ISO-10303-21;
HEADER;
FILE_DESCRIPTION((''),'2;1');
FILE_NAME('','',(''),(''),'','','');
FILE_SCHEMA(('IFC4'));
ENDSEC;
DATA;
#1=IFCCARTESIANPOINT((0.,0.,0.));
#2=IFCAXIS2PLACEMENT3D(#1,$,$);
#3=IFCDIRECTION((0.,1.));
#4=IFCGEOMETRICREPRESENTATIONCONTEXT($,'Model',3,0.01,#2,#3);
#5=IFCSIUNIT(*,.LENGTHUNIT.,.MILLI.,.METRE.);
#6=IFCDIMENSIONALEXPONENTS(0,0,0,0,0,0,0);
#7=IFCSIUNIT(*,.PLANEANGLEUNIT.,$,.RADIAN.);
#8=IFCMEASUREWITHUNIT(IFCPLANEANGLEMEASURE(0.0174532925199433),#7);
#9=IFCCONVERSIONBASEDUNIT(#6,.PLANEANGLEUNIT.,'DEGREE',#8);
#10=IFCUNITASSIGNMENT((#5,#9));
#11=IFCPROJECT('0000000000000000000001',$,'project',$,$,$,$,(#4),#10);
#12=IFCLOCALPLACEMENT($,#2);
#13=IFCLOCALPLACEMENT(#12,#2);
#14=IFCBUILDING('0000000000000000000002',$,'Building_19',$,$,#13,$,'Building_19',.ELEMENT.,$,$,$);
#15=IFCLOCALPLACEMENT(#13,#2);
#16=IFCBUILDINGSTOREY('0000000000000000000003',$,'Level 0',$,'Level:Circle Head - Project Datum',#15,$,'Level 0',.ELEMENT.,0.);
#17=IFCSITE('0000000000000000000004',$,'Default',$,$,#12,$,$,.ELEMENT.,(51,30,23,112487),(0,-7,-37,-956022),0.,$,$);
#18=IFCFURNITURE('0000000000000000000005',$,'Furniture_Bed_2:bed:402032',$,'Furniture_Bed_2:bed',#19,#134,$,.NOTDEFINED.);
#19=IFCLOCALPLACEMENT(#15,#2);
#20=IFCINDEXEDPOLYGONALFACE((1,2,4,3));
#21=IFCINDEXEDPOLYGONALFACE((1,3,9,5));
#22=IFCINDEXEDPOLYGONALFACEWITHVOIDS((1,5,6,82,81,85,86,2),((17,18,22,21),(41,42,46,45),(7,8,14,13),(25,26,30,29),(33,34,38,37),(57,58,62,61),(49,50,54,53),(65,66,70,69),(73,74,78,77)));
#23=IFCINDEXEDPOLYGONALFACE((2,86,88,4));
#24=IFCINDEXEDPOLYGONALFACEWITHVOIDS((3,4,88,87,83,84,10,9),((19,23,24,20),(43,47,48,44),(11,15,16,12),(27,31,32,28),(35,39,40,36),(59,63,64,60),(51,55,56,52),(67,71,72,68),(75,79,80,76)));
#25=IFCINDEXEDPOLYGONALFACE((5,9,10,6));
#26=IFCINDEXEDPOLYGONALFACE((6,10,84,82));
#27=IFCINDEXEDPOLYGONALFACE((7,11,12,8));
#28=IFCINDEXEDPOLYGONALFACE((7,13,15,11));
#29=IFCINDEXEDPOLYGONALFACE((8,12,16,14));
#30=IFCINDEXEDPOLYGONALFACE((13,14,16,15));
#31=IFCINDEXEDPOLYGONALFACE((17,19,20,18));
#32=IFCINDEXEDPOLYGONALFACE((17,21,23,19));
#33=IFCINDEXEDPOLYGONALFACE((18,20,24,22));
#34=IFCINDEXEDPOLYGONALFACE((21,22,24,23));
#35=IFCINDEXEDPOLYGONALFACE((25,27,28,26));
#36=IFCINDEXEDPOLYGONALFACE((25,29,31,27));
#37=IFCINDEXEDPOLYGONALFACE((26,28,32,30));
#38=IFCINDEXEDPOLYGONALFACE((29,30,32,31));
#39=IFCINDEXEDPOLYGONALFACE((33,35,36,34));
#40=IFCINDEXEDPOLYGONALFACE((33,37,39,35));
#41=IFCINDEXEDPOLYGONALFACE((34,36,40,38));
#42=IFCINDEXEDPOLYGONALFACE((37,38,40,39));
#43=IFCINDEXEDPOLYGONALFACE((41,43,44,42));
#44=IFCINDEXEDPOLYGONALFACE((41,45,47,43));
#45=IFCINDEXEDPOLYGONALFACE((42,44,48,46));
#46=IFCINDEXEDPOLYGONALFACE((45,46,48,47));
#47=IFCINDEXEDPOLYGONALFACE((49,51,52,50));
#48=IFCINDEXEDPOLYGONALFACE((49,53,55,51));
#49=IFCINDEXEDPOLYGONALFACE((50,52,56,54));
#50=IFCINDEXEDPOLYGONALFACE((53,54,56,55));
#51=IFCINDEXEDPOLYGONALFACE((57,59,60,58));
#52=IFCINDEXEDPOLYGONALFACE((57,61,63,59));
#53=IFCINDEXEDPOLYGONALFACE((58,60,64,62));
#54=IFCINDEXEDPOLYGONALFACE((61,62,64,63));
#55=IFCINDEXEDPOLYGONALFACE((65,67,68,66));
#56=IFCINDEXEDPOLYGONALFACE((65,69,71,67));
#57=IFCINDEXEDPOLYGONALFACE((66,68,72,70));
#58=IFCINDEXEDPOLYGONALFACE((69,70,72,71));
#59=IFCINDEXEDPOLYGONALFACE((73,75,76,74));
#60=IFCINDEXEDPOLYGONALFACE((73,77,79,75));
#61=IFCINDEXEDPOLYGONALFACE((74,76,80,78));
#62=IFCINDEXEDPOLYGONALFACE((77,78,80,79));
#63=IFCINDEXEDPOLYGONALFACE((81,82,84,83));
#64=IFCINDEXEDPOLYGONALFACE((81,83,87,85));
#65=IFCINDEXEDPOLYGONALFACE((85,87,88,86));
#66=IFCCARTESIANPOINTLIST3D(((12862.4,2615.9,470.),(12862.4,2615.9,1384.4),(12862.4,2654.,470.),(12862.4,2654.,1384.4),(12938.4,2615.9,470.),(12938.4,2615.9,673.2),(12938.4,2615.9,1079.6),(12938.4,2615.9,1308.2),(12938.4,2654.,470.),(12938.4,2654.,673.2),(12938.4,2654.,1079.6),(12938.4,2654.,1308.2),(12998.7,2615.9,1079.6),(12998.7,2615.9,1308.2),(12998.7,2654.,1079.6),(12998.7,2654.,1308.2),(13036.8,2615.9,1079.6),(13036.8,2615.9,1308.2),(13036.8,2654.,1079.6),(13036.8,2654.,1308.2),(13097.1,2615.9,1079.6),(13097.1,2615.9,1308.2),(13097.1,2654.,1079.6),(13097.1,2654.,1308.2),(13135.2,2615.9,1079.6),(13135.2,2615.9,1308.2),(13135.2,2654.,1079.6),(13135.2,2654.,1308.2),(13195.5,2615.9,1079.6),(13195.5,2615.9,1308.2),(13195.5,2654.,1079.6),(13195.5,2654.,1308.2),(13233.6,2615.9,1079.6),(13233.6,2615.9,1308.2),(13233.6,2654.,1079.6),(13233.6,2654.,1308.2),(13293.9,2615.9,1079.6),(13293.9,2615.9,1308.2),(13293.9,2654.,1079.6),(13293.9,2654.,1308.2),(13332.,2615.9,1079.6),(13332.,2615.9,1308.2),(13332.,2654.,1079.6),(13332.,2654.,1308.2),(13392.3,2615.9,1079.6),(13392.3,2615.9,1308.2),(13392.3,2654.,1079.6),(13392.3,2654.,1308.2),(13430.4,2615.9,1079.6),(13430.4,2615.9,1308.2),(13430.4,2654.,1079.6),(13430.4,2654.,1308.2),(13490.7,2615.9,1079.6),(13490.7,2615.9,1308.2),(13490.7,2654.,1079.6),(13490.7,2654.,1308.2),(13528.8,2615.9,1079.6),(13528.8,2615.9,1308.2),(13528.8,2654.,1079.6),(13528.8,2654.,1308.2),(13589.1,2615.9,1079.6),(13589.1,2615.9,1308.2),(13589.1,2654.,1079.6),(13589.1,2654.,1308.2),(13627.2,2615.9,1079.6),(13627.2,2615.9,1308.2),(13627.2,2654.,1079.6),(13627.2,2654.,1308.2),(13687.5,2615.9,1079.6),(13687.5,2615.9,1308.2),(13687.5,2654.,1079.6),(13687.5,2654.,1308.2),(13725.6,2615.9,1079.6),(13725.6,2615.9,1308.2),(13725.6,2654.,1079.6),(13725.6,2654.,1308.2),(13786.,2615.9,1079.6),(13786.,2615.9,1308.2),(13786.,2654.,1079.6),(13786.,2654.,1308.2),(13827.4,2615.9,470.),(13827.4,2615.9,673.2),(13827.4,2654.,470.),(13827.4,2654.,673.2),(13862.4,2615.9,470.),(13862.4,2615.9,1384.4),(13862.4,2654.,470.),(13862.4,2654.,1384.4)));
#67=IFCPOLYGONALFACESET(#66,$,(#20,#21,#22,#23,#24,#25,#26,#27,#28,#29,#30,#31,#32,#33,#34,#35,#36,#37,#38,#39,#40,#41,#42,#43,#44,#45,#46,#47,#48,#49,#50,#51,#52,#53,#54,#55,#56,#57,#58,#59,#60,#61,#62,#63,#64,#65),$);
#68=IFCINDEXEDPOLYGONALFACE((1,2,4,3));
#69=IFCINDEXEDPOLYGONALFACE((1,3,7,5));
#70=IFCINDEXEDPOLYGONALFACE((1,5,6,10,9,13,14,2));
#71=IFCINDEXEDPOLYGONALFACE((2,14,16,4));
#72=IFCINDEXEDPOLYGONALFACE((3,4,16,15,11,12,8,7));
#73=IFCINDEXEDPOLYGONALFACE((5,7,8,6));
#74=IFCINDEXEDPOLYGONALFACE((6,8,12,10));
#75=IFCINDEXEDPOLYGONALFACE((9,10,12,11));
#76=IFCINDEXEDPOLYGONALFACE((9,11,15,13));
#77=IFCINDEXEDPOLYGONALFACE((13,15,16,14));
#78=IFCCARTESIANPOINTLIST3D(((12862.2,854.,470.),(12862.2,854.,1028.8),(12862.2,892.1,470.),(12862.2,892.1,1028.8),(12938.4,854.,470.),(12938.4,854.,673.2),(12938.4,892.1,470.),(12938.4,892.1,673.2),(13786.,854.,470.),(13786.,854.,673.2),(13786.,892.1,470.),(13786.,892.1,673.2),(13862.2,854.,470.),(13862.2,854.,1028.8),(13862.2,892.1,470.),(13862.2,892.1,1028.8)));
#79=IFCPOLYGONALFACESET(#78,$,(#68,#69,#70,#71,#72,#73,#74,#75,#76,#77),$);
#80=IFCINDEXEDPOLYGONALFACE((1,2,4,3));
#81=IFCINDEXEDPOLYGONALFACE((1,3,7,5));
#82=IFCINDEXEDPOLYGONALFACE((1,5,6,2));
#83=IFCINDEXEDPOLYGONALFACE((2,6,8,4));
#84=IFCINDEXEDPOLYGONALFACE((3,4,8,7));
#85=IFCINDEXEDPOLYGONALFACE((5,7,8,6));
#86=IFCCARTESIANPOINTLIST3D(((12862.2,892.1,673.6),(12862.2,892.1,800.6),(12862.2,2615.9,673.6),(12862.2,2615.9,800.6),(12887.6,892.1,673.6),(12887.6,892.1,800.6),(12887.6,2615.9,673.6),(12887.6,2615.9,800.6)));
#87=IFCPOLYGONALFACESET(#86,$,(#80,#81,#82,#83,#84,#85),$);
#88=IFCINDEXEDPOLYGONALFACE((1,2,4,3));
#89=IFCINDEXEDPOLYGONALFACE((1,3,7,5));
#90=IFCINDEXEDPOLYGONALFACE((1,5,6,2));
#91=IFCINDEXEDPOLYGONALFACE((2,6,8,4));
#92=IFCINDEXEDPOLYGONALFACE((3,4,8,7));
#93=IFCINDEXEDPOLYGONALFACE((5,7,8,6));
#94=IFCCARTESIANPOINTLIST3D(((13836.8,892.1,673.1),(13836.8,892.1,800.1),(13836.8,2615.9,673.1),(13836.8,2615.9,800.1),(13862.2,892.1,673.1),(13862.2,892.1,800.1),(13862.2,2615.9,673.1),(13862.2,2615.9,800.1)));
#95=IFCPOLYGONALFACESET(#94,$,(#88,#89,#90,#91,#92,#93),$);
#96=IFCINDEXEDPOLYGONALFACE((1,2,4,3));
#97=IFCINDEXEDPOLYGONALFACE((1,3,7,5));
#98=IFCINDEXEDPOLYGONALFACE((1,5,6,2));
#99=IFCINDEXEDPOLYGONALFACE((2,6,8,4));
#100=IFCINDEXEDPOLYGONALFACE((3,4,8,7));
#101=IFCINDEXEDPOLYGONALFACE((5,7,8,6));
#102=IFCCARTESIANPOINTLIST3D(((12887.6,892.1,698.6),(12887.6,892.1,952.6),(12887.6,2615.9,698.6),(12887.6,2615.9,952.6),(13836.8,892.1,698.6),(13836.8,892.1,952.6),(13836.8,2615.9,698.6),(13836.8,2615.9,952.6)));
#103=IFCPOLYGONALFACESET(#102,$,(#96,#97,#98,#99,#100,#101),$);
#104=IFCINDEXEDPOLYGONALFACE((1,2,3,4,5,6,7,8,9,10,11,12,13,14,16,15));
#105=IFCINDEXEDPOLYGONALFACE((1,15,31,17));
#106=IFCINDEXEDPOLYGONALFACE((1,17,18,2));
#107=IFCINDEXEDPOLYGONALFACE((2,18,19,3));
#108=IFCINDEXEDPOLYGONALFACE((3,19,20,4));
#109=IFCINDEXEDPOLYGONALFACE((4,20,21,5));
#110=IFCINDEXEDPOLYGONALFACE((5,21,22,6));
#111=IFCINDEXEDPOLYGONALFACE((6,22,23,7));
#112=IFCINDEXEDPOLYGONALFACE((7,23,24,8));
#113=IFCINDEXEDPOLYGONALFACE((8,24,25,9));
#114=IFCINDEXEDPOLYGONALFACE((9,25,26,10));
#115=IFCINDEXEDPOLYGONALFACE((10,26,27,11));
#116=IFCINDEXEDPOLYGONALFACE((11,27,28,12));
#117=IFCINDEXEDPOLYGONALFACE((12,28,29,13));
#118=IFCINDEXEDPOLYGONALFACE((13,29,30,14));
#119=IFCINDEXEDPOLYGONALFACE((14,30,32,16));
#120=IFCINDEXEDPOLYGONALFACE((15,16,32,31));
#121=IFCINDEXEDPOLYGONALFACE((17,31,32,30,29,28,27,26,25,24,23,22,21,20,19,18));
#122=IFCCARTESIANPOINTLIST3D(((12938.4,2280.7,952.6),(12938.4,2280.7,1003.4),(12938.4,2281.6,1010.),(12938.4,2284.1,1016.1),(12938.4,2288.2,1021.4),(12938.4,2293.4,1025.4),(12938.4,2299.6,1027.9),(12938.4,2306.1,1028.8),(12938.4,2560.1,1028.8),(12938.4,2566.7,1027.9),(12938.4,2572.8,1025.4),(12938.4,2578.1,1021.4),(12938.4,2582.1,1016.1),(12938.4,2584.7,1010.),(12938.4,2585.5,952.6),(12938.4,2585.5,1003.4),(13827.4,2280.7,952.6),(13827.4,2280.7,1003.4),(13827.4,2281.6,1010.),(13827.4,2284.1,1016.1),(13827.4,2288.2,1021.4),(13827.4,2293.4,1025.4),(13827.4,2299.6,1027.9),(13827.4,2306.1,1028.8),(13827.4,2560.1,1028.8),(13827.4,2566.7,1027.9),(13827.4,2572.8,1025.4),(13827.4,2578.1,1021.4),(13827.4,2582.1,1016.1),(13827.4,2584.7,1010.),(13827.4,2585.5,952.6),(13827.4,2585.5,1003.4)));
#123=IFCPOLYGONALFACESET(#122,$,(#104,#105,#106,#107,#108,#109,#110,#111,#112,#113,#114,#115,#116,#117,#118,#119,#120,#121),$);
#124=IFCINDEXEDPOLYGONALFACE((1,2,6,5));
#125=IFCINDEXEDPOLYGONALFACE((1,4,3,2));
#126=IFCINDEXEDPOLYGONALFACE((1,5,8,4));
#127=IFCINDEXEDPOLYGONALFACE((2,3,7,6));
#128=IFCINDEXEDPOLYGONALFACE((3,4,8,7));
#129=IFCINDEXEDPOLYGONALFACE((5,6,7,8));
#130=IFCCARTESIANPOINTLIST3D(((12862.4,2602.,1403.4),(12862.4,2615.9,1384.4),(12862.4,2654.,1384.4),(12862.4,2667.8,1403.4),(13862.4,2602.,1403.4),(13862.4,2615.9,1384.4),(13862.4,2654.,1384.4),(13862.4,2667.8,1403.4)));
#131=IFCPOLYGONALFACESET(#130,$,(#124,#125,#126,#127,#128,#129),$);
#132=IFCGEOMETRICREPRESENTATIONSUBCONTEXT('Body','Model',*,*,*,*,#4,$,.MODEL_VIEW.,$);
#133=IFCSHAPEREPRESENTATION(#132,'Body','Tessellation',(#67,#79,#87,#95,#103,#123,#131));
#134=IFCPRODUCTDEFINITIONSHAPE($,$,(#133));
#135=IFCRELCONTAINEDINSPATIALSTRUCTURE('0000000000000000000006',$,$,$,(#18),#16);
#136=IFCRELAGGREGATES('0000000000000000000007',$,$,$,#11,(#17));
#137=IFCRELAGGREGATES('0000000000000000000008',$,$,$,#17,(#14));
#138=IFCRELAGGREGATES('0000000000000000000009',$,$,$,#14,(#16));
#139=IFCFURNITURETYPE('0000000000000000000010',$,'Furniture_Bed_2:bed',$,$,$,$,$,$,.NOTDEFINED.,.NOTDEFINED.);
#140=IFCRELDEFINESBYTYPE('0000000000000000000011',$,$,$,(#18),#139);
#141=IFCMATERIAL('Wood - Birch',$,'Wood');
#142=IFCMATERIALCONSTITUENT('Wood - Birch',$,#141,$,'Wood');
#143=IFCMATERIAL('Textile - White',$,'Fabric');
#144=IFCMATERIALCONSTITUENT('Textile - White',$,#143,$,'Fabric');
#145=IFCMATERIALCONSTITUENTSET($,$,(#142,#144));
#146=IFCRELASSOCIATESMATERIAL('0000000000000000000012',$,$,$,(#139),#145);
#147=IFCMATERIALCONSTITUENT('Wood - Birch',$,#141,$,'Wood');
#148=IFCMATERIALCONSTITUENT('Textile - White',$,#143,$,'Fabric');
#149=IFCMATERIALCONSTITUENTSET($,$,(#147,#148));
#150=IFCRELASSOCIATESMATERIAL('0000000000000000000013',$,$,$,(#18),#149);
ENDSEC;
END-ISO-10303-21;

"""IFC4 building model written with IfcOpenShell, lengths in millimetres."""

from ifc_helpers import new_model, entity, si_unit, converted_unit, direction, frame, origin, place, context, subcontext, project, spatial, line, arc, indexed_curve, outline, extrude, source, transform, mapped, material, constituent, constituent_set, type_object, type_shapes, element, save


model = new_model("IFC4")

# Units and contexts
model_context = context("Model", 3, precision=0.01, world=origin(), true_north=direction((0.0, 1.0)))
body_context = subcontext(model_context, "Body", "Model", "MODEL_VIEW")
ifc_project = project(units=[si_unit("LENGTHUNIT", "METRE", prefix="MILLI"), converted_unit("PLANEANGLEUNIT", "DEGREE", entity("IfcPlaneAngleMeasure", 0.0174532925199433), si_unit("PLANEANGLEUNIT", "RADIAN"), dimensions=[0, 0, 0, 0, 0, 0, 0])], contexts=[model_context])

# Site, building, storey
site_placement = place(None, origin())
site = spatial("IfcSite", under=ifc_project, at=site_placement, Name="Default", CompositionType="ELEMENT", RefLatitude=(51, 30, 23, 112487), RefLongitude=(0, -7, -37, -956022), RefElevation=0.0)
building_placement = place(site_placement, origin())
building = spatial("IfcBuilding", under=site, at=building_placement, Name="Building_19", LongName="Building_19", CompositionType="ELEMENT")
storey_placement = place(building_placement, origin())
storey = spatial("IfcBuildingStorey", under=building, at=storey_placement, Name="Level 0", ObjectType="Level:Circle Head - Project Datum", LongName="Level 0", CompositionType="ELEMENT", Elevation=0.0)

# Furniture
ifc_material_1 = material(Name="Wood - Birch", Category="Wood")
ifc_constituent_1 = constituent(ifc_material_1, Name="Wood - Birch", Category="Wood")
ifc_material_2 = material(Name="Textile - White", Category="Fabric")
ifc_constituent_2 = constituent(ifc_material_2, Name="Textile - White", Category="Fabric")
ifc_constituent_set_1 = constituent_set(constituents=[ifc_constituent_1, ifc_constituent_2])
ifc_constituent_3 = constituent(ifc_material_1, Name="Wood - Birch", Category="Wood")
ifc_constituent_4 = constituent(ifc_material_2, Name="Textile - White", Category="Fabric")
ifc_constituent_set_2 = constituent_set(constituents=[ifc_constituent_3, ifc_constituent_4])
furniture_type_1 = type_object("IfcFurnitureType", Name="Furniture_Bed_2:bed", AssemblyPlace="NOTDEFINED", PredefinedType="NOTDEFINED", material=ifc_constituent_set_2)
shared_shape_1 = source(origin(), body_context, "Body", "SweptSolid", [
    extrude(outline(indexed_curve([(-635.0, -489.8), (279.4, -489.8), (279.4, -454.7), (76.2, -454.7), (76.2, 434.3), (279.4, 434.3), (279.4, 510.3), (-635.0, 510.3), (-635.0, -489.8)], self_intersect=False), holes=[indexed_curve([(-558.8, 374.0), (-558.8, 434.3), (-330.2, 434.3), (-330.2, 374.0), (-558.8, 374.0)], self_intersect=False), indexed_curve([(-558.8, 275.5), (-558.8, 335.9), (-330.2, 335.9), (-330.2, 275.5), (-558.8, 275.5)], self_intersect=False), indexed_curve([(-558.8, 177.1), (-558.8, 237.4), (-330.2, 237.4), (-330.2, 177.1), (-558.8, 177.1)], self_intersect=False), indexed_curve([(-558.8, 78.7), (-558.8, 139.0), (-330.2, 139.0), (-330.2, 78.7), (-558.8, 78.7)], self_intersect=False), indexed_curve([(-558.8, -118.1), (-558.8, -57.8), (-330.2, -57.8), (-330.2, -118.1), (-558.8, -118.1)], self_intersect=False), indexed_curve([(-558.8, -216.5), (-558.8, -156.2), (-330.2, -156.2), (-330.2, -216.5), (-558.8, -216.5)], self_intersect=False), indexed_curve([(-558.8, -314.9), (-558.8, -254.6), (-330.2, -254.6), (-330.2, -314.9), (-558.8, -314.9)], self_intersect=False), indexed_curve([(-558.8, -413.3), (-558.8, -353.0), (-330.2, -353.0), (-330.2, -413.3), (-558.8, -413.3)], self_intersect=False), indexed_curve([(-558.8, -19.7), (-558.8, 40.6), (-330.2, 40.6), (-330.2, -19.7), (-558.8, -19.7)], self_intersect=False)]), frame((-8.6, -38.1, 279.4), z_axis=(0.0, 1.0, 0.0), x_axis=(0.0, 0.0, -1.0)), (0.0, 0.0, 1.0), 38.1),
    extrude(outline(indexed_curve([(423.8, -190.5), (500.0, -190.5), (500.0, 368.3), (-500.0, 368.3), (-500.0, -190.5), (-423.8, -190.5), (-423.8, 12.7), (423.8, 12.7), (423.8, -190.5)], self_intersect=False)), frame((-19.1, -1800.0, 190.5), z_axis=(0.0, 1.0, 0.0), x_axis=(-1.0, 0.0, 0.0)), (0.0, 0.0, 1.0), 38.1),
    extrude(outline(indexed_curve([(-12.7, -861.9), (12.7, -861.9), (12.7, 861.9), (-12.7, 861.9), (-12.7, -861.9)], self_intersect=False)), frame((-506.4, -900.0, 203.6)), (0.0, 0.0, 1.0), 127.0),
    extrude(outline(indexed_curve([(-12.7, -861.9), (12.7, -861.9), (12.7, 861.9), (-12.7, 861.9), (-12.7, -861.9)], self_intersect=False)), frame((468.2, -900.0, 203.1)), (0.0, 0.0, 1.0), 127.0),
    extrude(outline(indexed_curve([(-474.6, -861.9), (474.6, -861.9), (474.6, 861.9), (-474.6, 861.9), (-474.6, -861.9)], self_intersect=False)), frame((-19.0, -900.0, 228.6), z_axis=(0.0, 0.0, 1.0), x_axis=(-1.0, 0.0, 0.0)), (0.0, 0.0, 1.0), 254.0),
    extrude(outline(indexed_curve([(-152.4, -42.3), (152.4, -42.3), (152.4, 8.5), (145.0, 26.4), (127.0, 33.9), (-127.0, 33.9), (-145.0, 26.4), (-152.4, 8.5)], segments=[line(1, 2, 3), arc(3, 4, 5), line(5, 6), arc(6, 7, 8), line(8, 1)], self_intersect=False)), frame((-442.9, -220.8, 524.9), z_axis=(1.0, 0.0, 0.0), x_axis=(0.0, 1.0, 0.0)), (0.0, 0.0, 1.0), 889.0),
    extrude(outline(indexed_curve([(-19.1, -9.5), (19.0, -9.5), (32.9, 9.5), (-32.9, 9.5), (-19.1, -9.5)], self_intersect=False)), frame((-518.8, -19.0, 923.9), z_axis=(1.0, 0.0, 0.0), x_axis=(0.0, 1.0, 0.0)), (0.0, 0.0, 1.0), 1000.1),
])
type_shapes(furniture_type_1, [shared_shape_1])
furniture_1_placement = place(storey_placement, frame((13381.2, 2654.0, 470.0)))
element("IfcFurniture", 1, at=furniture_1_placement, inside=storey, type_object=furniture_type_1, material=ifc_constituent_set_1, Name="Furniture_Bed_2:bed:402032", ObjectType="Furniture_Bed_2:bed", PredefinedType="NOTDEFINED", context=body_context, shape_type="MappedRepresentation", body=[
    mapped(shared_shape_1, transform((0.0, 0.0, 0.0), scale=1.0)),
])

save(model, "model.ifc")
